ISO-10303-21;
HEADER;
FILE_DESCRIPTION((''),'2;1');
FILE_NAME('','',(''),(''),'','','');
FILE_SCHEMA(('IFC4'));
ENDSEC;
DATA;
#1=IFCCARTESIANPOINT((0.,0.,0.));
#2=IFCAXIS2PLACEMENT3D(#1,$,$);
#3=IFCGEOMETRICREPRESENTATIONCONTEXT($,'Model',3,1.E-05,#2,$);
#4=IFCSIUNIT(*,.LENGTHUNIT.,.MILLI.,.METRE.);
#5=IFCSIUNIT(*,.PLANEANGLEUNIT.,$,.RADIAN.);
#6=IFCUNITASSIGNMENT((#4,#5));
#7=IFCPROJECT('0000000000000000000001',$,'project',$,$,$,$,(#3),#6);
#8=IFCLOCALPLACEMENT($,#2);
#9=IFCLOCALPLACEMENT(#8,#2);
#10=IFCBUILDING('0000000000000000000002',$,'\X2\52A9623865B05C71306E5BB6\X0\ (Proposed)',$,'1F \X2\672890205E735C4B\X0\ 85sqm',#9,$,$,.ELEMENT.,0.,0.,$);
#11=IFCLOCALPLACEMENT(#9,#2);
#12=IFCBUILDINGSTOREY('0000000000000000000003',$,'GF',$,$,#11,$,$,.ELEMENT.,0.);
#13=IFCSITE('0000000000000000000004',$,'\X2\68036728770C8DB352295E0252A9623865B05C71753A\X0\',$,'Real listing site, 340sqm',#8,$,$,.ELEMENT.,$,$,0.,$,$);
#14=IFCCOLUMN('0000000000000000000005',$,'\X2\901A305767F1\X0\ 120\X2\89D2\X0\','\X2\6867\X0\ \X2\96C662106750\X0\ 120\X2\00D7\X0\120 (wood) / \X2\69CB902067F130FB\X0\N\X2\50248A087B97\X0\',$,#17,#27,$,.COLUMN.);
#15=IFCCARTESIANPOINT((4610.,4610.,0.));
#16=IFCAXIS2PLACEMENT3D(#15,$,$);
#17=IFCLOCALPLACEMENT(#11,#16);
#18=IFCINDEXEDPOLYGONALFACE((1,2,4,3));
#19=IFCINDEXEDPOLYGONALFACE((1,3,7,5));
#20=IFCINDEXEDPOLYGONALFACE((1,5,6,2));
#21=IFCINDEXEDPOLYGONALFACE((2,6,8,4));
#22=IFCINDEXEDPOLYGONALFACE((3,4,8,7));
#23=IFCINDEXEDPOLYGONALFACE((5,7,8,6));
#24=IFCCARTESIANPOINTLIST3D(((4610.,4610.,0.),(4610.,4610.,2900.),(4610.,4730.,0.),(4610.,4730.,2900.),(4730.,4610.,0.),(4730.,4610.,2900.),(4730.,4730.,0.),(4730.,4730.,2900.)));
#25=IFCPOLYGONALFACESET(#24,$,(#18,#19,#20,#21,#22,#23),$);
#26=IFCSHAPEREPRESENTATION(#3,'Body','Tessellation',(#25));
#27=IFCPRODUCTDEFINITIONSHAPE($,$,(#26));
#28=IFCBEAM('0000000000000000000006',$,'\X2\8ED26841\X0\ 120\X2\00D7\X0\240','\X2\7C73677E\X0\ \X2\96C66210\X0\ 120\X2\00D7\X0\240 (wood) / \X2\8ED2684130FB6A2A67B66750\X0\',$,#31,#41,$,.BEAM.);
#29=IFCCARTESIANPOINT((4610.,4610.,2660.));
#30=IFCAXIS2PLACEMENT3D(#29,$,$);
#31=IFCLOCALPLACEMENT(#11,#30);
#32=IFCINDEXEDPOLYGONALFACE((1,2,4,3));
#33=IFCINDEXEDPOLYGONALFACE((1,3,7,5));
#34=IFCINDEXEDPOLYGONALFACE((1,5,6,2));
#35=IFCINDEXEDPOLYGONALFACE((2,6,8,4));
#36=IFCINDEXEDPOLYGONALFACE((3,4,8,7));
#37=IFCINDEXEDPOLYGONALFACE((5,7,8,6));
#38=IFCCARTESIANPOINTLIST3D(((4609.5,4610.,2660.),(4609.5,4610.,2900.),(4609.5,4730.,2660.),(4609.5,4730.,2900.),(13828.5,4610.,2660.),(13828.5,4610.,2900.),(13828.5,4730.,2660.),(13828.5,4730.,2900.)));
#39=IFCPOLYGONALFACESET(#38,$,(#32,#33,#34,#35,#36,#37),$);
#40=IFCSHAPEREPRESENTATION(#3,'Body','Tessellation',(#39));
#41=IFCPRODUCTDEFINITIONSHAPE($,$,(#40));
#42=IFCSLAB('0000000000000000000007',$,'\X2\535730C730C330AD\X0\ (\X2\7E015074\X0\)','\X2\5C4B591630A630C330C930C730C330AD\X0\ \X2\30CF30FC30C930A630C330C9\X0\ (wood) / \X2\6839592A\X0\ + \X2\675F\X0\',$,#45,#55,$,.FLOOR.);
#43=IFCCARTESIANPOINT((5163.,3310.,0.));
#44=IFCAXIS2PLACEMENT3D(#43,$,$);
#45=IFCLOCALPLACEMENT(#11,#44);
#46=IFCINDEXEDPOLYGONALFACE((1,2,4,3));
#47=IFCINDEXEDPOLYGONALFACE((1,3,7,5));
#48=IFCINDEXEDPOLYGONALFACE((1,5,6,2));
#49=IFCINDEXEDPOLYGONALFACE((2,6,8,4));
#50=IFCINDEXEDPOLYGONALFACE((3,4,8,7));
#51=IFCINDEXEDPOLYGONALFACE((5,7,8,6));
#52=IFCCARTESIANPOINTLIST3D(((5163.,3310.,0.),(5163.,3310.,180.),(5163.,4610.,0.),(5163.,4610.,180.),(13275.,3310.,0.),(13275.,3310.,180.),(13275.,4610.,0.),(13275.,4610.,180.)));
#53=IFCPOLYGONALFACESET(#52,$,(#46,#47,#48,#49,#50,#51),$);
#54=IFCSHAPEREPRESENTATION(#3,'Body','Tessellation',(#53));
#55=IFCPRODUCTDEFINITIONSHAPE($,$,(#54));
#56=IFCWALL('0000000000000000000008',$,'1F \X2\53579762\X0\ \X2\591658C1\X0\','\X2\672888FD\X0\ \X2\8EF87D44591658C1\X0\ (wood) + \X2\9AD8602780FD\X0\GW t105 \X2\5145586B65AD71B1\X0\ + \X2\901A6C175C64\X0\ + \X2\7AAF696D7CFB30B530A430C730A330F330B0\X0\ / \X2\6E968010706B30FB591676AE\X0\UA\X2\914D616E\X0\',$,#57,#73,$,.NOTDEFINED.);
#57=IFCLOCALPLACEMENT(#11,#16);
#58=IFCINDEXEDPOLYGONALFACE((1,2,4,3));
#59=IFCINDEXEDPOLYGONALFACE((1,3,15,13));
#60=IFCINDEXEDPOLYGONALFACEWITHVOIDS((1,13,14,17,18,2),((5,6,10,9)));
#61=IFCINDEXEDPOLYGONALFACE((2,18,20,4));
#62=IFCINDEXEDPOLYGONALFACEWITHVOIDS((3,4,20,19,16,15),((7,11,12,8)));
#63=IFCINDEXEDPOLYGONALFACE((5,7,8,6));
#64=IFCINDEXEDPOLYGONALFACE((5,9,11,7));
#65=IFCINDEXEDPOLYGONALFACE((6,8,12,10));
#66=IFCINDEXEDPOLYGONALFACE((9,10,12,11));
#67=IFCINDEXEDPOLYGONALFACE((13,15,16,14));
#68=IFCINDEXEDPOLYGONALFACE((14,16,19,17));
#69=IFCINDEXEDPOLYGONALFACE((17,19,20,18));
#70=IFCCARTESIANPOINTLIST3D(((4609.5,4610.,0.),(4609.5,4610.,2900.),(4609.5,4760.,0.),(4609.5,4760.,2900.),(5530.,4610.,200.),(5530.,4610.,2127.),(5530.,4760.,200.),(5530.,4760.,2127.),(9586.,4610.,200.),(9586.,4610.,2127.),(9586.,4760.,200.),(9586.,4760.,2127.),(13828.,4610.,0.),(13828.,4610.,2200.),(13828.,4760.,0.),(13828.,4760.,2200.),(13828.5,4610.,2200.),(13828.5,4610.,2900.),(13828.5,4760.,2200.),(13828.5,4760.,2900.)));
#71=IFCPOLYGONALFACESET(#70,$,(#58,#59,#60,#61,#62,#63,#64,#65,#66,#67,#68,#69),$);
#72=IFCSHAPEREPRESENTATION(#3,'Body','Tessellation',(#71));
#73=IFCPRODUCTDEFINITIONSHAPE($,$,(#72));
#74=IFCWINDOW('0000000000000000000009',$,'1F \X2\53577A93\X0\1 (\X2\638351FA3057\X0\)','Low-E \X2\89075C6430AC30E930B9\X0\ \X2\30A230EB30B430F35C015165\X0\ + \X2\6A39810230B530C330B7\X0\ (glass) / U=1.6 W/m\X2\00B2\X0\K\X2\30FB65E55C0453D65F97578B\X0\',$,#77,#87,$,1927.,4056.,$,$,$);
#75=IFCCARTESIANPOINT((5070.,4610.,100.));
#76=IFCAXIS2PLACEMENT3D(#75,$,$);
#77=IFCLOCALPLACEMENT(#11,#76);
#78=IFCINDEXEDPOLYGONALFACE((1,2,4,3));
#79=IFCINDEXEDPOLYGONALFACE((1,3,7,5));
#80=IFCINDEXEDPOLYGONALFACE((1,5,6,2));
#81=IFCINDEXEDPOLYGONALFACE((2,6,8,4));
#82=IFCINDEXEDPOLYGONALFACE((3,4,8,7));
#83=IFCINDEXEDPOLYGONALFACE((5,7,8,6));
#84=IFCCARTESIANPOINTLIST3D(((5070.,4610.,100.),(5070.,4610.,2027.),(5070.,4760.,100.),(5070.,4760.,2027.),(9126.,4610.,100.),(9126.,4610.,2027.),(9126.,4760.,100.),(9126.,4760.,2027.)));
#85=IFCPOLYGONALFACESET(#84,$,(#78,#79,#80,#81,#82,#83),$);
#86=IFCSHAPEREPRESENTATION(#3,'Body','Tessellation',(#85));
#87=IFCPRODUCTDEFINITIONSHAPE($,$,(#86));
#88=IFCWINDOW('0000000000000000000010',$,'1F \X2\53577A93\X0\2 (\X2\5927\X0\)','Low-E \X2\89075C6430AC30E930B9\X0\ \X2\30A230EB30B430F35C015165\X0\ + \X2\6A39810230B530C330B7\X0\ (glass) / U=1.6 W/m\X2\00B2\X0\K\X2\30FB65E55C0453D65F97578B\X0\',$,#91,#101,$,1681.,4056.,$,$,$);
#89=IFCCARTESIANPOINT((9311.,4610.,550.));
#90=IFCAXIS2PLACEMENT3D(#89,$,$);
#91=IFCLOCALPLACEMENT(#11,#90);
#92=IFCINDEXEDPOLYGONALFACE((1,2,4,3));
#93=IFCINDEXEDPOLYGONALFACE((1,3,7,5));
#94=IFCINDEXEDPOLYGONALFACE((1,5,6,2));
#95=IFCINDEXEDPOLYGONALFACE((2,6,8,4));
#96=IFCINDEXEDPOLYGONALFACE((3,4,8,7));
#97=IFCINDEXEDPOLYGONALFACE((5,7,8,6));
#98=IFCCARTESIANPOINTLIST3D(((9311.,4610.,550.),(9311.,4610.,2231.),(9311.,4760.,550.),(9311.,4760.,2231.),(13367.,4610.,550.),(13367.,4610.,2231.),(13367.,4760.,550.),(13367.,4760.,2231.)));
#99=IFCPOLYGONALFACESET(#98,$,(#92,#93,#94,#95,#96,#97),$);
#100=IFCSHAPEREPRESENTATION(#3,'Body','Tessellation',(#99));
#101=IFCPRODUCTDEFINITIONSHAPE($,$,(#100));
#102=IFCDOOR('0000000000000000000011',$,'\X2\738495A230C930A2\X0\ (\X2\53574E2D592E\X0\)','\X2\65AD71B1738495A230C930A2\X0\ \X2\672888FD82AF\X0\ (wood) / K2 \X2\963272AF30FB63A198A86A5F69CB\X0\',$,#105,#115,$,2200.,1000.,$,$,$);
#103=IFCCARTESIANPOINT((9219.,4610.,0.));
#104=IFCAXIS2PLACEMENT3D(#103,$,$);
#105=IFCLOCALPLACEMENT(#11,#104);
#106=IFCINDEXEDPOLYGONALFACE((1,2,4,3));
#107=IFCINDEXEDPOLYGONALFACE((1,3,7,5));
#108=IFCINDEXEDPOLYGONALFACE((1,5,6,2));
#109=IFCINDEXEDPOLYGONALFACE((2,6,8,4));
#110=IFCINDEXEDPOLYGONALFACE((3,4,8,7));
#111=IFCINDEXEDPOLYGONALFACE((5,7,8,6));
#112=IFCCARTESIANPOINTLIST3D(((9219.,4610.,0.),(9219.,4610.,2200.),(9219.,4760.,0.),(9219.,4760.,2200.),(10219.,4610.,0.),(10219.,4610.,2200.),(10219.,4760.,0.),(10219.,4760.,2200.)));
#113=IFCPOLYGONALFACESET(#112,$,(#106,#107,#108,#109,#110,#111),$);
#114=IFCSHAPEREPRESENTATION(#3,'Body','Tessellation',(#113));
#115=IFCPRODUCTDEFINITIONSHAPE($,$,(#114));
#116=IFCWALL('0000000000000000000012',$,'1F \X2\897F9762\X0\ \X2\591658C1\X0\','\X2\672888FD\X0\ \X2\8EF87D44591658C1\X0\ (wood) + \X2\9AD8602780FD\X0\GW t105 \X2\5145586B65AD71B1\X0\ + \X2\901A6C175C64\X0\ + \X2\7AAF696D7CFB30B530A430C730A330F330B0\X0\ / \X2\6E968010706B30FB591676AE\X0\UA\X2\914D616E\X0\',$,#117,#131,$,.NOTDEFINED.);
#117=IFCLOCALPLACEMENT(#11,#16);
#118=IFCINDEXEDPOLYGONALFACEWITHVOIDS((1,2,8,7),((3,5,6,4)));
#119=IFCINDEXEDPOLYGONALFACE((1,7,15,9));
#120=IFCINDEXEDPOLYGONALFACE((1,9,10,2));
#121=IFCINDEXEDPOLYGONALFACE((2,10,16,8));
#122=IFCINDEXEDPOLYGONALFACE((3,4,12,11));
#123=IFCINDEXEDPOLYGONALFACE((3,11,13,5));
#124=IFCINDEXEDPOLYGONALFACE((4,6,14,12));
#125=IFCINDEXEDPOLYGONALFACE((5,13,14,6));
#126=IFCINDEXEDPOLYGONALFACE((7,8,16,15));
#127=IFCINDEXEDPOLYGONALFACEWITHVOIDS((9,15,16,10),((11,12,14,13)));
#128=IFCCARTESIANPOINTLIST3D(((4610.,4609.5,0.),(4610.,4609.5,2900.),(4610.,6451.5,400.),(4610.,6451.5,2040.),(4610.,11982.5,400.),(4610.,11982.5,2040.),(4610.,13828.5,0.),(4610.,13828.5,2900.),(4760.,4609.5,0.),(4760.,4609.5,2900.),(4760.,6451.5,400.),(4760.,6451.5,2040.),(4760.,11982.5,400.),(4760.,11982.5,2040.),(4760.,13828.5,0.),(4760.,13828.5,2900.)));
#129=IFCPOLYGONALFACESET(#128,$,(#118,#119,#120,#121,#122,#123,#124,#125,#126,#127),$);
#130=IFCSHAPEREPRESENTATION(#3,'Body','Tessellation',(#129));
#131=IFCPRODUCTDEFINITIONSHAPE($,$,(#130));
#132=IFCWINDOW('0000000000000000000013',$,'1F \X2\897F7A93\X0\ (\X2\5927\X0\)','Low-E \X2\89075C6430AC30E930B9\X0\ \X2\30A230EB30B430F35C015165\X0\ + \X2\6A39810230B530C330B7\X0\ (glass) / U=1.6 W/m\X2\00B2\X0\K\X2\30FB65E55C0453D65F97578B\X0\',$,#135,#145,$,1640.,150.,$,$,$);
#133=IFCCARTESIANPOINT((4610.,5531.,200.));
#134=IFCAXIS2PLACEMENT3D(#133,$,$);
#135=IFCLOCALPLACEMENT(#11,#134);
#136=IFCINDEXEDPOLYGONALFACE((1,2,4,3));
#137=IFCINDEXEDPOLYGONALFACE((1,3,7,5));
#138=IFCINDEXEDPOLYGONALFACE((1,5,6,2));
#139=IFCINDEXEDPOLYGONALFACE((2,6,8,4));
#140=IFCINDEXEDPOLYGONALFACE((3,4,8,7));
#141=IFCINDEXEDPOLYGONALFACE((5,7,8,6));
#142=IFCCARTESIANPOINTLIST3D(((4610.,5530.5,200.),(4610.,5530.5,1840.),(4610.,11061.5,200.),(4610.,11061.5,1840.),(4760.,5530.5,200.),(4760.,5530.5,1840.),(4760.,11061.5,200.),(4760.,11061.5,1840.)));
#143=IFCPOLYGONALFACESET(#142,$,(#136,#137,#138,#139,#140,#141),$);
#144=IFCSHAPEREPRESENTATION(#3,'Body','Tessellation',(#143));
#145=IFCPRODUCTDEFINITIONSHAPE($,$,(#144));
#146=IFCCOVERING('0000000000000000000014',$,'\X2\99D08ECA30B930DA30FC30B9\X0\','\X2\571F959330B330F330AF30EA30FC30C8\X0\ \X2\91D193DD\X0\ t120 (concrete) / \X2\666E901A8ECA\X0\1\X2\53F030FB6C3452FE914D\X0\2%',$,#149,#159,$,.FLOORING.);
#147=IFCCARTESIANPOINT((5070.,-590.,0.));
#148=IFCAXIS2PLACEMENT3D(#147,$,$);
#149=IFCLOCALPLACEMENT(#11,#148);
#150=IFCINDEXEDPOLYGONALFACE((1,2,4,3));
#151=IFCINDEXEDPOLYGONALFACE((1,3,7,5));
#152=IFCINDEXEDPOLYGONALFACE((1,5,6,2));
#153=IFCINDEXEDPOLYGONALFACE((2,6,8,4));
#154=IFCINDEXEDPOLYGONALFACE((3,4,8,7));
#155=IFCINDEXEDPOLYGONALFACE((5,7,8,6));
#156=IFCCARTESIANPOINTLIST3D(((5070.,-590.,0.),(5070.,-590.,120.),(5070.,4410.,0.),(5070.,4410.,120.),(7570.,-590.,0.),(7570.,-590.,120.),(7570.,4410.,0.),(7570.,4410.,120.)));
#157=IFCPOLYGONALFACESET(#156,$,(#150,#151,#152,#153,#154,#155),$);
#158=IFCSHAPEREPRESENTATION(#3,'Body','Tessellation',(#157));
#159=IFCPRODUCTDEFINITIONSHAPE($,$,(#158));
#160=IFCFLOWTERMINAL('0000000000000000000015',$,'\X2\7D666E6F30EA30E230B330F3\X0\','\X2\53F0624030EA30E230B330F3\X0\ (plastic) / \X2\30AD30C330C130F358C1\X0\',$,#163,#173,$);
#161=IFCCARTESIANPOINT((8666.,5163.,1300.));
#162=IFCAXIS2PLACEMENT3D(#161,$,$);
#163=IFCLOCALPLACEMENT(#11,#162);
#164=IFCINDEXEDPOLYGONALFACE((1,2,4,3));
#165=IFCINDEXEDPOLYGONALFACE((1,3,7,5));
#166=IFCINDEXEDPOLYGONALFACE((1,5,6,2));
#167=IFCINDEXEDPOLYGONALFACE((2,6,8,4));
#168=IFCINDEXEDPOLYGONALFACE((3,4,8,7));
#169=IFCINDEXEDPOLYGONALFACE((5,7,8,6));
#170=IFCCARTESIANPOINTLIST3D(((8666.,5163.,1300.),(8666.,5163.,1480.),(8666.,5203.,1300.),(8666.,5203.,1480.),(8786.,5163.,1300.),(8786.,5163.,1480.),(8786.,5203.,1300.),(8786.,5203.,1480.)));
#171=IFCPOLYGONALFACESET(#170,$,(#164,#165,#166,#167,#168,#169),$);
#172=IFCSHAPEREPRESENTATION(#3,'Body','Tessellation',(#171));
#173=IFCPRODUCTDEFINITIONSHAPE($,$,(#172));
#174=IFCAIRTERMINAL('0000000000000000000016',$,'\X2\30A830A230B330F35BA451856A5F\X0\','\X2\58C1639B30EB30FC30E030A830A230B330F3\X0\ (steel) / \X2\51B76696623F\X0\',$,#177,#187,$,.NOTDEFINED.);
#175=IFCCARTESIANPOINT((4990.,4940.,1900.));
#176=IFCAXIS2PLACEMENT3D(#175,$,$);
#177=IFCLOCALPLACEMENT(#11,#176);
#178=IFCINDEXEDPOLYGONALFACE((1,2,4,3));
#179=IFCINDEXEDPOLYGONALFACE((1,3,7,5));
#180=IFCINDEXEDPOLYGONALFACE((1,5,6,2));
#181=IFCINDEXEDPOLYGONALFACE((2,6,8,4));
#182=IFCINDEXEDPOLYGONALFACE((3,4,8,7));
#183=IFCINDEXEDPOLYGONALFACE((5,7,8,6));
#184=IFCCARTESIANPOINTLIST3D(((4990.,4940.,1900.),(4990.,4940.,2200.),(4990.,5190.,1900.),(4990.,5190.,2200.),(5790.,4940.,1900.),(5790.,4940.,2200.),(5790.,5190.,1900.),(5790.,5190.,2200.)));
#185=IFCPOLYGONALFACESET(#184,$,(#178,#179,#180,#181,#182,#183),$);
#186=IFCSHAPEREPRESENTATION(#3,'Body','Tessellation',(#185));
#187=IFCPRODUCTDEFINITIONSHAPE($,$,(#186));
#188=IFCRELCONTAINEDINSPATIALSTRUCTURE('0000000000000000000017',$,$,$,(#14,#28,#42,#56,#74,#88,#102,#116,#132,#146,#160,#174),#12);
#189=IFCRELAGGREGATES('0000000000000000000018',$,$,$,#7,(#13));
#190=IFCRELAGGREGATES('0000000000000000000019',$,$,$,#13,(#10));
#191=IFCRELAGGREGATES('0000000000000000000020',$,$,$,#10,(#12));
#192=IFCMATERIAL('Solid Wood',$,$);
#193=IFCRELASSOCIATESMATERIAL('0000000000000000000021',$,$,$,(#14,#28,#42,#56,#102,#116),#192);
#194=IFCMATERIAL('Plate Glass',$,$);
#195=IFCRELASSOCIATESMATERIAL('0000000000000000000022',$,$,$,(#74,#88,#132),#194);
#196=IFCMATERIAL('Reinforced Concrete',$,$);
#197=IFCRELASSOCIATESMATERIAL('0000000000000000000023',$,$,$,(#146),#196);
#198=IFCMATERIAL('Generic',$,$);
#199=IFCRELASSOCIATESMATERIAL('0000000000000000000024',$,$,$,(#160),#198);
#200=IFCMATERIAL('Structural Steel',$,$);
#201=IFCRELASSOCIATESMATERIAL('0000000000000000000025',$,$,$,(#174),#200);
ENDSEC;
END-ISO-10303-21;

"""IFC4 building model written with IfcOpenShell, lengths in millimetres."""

from ifc_helpers import new_model, si_unit, frame, frame_2d, origin, place, context, project, spatial, rectangle, extrude, material, element, fill, save


model = new_model("IFC4")

# Units and contexts
model_context = context("Model", 3, precision=1e-05, world=origin())
ifc_project = project(units=[si_unit("LENGTHUNIT", "METRE", prefix="MILLI"), si_unit("PLANEANGLEUNIT", "RADIAN")], contexts=[model_context])

# Site, building, storey
site_placement = place(None, origin())
site = spatial("IfcSite", under=ifc_project, at=site_placement, Name="栃木県足利市助戸新山町", ObjectType="Real listing site, 340sqm", CompositionType="ELEMENT", RefElevation=0.0)
building_placement = place(site_placement, origin())
building = spatial("IfcBuilding", under=site, at=building_placement, Name="助戸新山の家 (Proposed)", ObjectType="1F 木造平屋 85sqm", CompositionType="ELEMENT", ElevationOfRefHeight=0.0, ElevationOfTerrain=0.0)
storey_placement = place(building_placement, origin())
storey = spatial("IfcBuildingStorey", under=building, at=storey_placement, Name="GF", CompositionType="ELEMENT", Elevation=0.0)

# Column
ifc_material_1 = material(Name="Solid Wood")
column_1_placement = place(storey_placement, frame((4610.0, 4610.0, 0.0)))
element("IfcColumn", 1, at=column_1_placement, inside=storey, material=ifc_material_1, Name="通し柱 120角", Description="桧 集成材 120×120 (wood) / 構造柱・N値計算", PredefinedType="COLUMN", context=model_context, shape_type="SweptSolid", body=[
    extrude(rectangle(XDim=120.0, YDim=120.0, at=frame_2d((60.0, 60.0))), frame((4610.0, 4610.0, 0.0)), (0.0, 0.0, 1.0), 2900.0),
])

# Beam
beam_1_placement = place(storey_placement, frame((4610.0, 4610.0, 2660.0)))
element("IfcBeam", 2, at=beam_1_placement, inside=storey, material=ifc_material_1, Name="軒桁 120×240", Description="米松 集成 120×240 (wood) / 軒桁・横架材", PredefinedType="BEAM", context=model_context, shape_type="SweptSolid", body=[
    extrude(rectangle(XDim=9219.0, YDim=120.0, at=frame_2d((4609.0, 60.0))), frame((4610.0, 4610.0, 2660.0)), (0.0, 0.0, 1.0), 240.0),
])

# Slab
ifc_material_2 = material(Name="Reinforced Concrete")
slab_1_placement = place(storey_placement, frame((5163.0, 3310.0, 0.0)))
element("IfcSlab", 3, at=slab_1_placement, inside=storey, material=ifc_material_1, Name="南デッキ (縁側)", Description="屋外ウッドデッキ ハードウッド (wood) / 根太 + 束", PredefinedType="FLOOR", context=model_context, shape_type="SweptSolid", body=[
    extrude(rectangle(XDim=8112.0, YDim=1300.0, at=frame_2d((4056.0, 650.0))), frame((5163.0, 3310.0, 0.0)), (0.0, 0.0, 1.0), 180.0),
])

# Wall, openings, windows, door
wall_1_placement = place(storey_placement, frame((4610.0, 4610.0, 0.0)))
wall_1 = element("IfcWall", 4, at=wall_1_placement, inside=storey, material=ifc_material_1, Name="1F 南面 外壁", Description="木製 軸組外壁 (wood) + 高性能GW t105 充填断熱 + 通気層 + 窯業系サイディング / 準耐火・外皮UA配慮", PredefinedType="NOTDEFINED", context=model_context, shape_type="SweptSolid", body=[
    extrude(rectangle(XDim=9219.0, YDim=150.0, at=frame_2d((4609.0, 75.0))), frame((4610.0, 4610.0, 0.0)), (0.0, 0.0, 1.0), 2900.0),
])
opening_1_placement = place(storey_placement, frame((5070.0, 4610.0, 100.0)))
opening_1 = element("IfcOpeningElement", 5, at=opening_1_placement, cuts=wall_1, PredefinedType="NOTDEFINED", context=model_context, shape_type="SweptSolid", body=[
    extrude(rectangle(XDim=4056.0, YDim=150.0, at=frame_2d((2028.0, 75.0))), frame((5070.0, 4610.0, 100.0)), (0.0, 0.0, 1.0), 1927.0),
])
opening_2_placement = place(storey_placement, frame((9311.0, 4610.0, 550.0)))
opening_2 = element("IfcOpeningElement", 6, at=opening_2_placement, cuts=wall_1, PredefinedType="NOTDEFINED", context=model_context, shape_type="SweptSolid", body=[
    extrude(rectangle(XDim=4056.0, YDim=150.0, at=frame_2d((2028.0, 75.0))), frame((9311.0, 4610.0, 550.0)), (0.0, 0.0, 1.0), 1681.0),
])
opening_3_placement = place(storey_placement, frame((9219.0, 4610.0, 0.0)))
opening_3 = element("IfcOpeningElement", 7, at=opening_3_placement, cuts=wall_1, PredefinedType="NOTDEFINED", context=model_context, shape_type="SweptSolid", body=[
    extrude(rectangle(XDim=1000.0, YDim=150.0, at=frame_2d((500.0, 75.0))), frame((9219.0, 4610.0, 0.0)), (0.0, 0.0, 1.0), 2200.0),
])
ifc_material_3 = material(Name="Plate Glass")
window_1_placement = place(storey_placement, frame((5070.0, 4610.0, 100.0)))
window_1 = element("IfcWindow", 8, at=window_1_placement, inside=storey, material=ifc_material_3, Name="1F 南窓1 (掃出し)", Description="Low-E 複層ガラス アルゴン封入 + 樹脂サッシ (glass) / U=1.6 W/m²K・日射取得型", OverallHeight=1927.0, OverallWidth=4056.0, context=model_context, shape_type="SweptSolid", body=[
    extrude(rectangle(XDim=4056.0, YDim=150.0, at=frame_2d((2028.0, 75.0))), frame((5070.0, 4610.0, 100.0)), (0.0, 0.0, 1.0), 1927.0),
])
fill(opening_1, window_1)
window_2_placement = place(storey_placement, frame((9311.0, 4610.0, 550.0)))
window_2 = element("IfcWindow", 9, at=window_2_placement, inside=storey, material=ifc_material_3, Name="1F 南窓2 (大)", Description="Low-E 複層ガラス アルゴン封入 + 樹脂サッシ (glass) / U=1.6 W/m²K・日射取得型", OverallHeight=1681.0, OverallWidth=4056.0, context=model_context, shape_type="SweptSolid", body=[
    extrude(rectangle(XDim=4056.0, YDim=150.0, at=frame_2d((2028.0, 75.0))), frame((9311.0, 4610.0, 550.0)), (0.0, 0.0, 1.0), 1681.0),
])
fill(opening_2, window_2)
door_placement = place(storey_placement, frame((9219.0, 4610.0, 0.0)))
door = element("IfcDoor", 10, at=door_placement, inside=storey, material=ifc_material_1, Name="玄関ドア (南中央)", Description="断熱玄関ドア 木製芯 (wood) / K2 防犯・採風機構", OverallHeight=2200.0, OverallWidth=1000.0, context=model_context, shape_type="SweptSolid", body=[
    extrude(rectangle(XDim=1000.0, YDim=150.0, at=frame_2d((500.0, 75.0))), frame((9219.0, 4610.0, 0.0)), (0.0, 0.0, 1.0), 2200.0),
])
fill(opening_3, door)

# Wall, opening, window
wall_2_placement = place(storey_placement, frame((4610.0, 4610.0, 0.0)))
wall_2 = element("IfcWall", 11, at=wall_2_placement, inside=storey, material=ifc_material_1, Name="1F 西面 外壁", Description="木製 軸組外壁 (wood) + 高性能GW t105 充填断熱 + 通気層 + 窯業系サイディング / 準耐火・外皮UA配慮", PredefinedType="NOTDEFINED", context=model_context, shape_type="SweptSolid", body=[
    extrude(rectangle(XDim=150.0, YDim=9219.0, at=frame_2d((75.0, 4609.0))), frame((4610.0, 4610.0, 0.0)), (0.0, 0.0, 1.0), 2900.0),
])
opening_4_placement = place(storey_placement, frame((4610.0, 5531.0, 200.0)))
opening_4 = element("IfcOpeningElement", 12, at=opening_4_placement, cuts=wall_2, PredefinedType="NOTDEFINED", context=model_context, shape_type="SweptSolid", body=[
    extrude(rectangle(XDim=150.0, YDim=5531.0, at=frame_2d((75.0, 2765.0))), frame((4610.0, 5531.0, 200.0)), (0.0, 0.0, 1.0), 1640.0),
])
window_3_placement = place(storey_placement, frame((4610.0, 5531.0, 200.0)))
window_3 = element("IfcWindow", 13, at=window_3_placement, inside=storey, material=ifc_material_3, Name="1F 西窓 (大)", Description="Low-E 複層ガラス アルゴン封入 + 樹脂サッシ (glass) / U=1.6 W/m²K・日射取得型", OverallHeight=1640.0, OverallWidth=150.0, context=model_context, shape_type="SweptSolid", body=[
    extrude(rectangle(XDim=150.0, YDim=5531.0, at=frame_2d((75.0, 2765.0))), frame((4610.0, 5531.0, 200.0)), (0.0, 0.0, 1.0), 1640.0),
])
fill(opening_4, window_3)

# Shared definitions
ifc_material_4 = material(Name="Structural Steel")

# Covering
ifc_material_5 = material(Name="Generic")
covering_1_placement = place(storey_placement, frame((5070.0, -590.0, 0.0)))
element("IfcCovering", 14, at=covering_1_placement, inside=storey, material=ifc_material_2, Name="駐車スペース", Description="土間コンクリート 金鏝 t120 (concrete) / 普通車1台・水勾配2%", PredefinedType="FLOORING", context=model_context, shape_type="SweptSolid", body=[
    extrude(rectangle(XDim=2500.0, YDim=5000.0, at=frame_2d((1250.0, 2500.0))), frame((5070.0, -590.0, 0.0)), (0.0, 0.0, 1.0), 120.0),
])

# Flow terminal
flow_terminal_placement = place(storey_placement, frame((8666.0, 5163.0, 1300.0)))
element("IfcFlowTerminal", 15, at=flow_terminal_placement, inside=storey, material=ifc_material_5, Name="給湯リモコン", Description="台所リモコン (plastic) / キッチン壁", context=model_context, shape_type="SweptSolid", body=[
    extrude(rectangle(XDim=120.0, YDim=40.0, at=frame_2d((60.0, 20.0))), frame((8666.0, 5163.0, 1300.0)), (0.0, 0.0, 1.0), 180.0),
])

# Air terminal
air_terminal_placement = place(storey_placement, frame((4990.0, 4940.0, 1900.0)))
element("IfcAirTerminal", 16, at=air_terminal_placement, inside=storey, material=ifc_material_4, Name="エアコン室内機", Description="壁掛ルームエアコン (steel) / 冷暖房", PredefinedType="NOTDEFINED", context=model_context, shape_type="SweptSolid", body=[
    extrude(rectangle(XDim=800.0, YDim=250.0, at=frame_2d((400.0, 125.0))), frame((4990.0, 4940.0, 1900.0)), (0.0, 0.0, 1.0), 300.0),
])

save(model, "model.ifc")
